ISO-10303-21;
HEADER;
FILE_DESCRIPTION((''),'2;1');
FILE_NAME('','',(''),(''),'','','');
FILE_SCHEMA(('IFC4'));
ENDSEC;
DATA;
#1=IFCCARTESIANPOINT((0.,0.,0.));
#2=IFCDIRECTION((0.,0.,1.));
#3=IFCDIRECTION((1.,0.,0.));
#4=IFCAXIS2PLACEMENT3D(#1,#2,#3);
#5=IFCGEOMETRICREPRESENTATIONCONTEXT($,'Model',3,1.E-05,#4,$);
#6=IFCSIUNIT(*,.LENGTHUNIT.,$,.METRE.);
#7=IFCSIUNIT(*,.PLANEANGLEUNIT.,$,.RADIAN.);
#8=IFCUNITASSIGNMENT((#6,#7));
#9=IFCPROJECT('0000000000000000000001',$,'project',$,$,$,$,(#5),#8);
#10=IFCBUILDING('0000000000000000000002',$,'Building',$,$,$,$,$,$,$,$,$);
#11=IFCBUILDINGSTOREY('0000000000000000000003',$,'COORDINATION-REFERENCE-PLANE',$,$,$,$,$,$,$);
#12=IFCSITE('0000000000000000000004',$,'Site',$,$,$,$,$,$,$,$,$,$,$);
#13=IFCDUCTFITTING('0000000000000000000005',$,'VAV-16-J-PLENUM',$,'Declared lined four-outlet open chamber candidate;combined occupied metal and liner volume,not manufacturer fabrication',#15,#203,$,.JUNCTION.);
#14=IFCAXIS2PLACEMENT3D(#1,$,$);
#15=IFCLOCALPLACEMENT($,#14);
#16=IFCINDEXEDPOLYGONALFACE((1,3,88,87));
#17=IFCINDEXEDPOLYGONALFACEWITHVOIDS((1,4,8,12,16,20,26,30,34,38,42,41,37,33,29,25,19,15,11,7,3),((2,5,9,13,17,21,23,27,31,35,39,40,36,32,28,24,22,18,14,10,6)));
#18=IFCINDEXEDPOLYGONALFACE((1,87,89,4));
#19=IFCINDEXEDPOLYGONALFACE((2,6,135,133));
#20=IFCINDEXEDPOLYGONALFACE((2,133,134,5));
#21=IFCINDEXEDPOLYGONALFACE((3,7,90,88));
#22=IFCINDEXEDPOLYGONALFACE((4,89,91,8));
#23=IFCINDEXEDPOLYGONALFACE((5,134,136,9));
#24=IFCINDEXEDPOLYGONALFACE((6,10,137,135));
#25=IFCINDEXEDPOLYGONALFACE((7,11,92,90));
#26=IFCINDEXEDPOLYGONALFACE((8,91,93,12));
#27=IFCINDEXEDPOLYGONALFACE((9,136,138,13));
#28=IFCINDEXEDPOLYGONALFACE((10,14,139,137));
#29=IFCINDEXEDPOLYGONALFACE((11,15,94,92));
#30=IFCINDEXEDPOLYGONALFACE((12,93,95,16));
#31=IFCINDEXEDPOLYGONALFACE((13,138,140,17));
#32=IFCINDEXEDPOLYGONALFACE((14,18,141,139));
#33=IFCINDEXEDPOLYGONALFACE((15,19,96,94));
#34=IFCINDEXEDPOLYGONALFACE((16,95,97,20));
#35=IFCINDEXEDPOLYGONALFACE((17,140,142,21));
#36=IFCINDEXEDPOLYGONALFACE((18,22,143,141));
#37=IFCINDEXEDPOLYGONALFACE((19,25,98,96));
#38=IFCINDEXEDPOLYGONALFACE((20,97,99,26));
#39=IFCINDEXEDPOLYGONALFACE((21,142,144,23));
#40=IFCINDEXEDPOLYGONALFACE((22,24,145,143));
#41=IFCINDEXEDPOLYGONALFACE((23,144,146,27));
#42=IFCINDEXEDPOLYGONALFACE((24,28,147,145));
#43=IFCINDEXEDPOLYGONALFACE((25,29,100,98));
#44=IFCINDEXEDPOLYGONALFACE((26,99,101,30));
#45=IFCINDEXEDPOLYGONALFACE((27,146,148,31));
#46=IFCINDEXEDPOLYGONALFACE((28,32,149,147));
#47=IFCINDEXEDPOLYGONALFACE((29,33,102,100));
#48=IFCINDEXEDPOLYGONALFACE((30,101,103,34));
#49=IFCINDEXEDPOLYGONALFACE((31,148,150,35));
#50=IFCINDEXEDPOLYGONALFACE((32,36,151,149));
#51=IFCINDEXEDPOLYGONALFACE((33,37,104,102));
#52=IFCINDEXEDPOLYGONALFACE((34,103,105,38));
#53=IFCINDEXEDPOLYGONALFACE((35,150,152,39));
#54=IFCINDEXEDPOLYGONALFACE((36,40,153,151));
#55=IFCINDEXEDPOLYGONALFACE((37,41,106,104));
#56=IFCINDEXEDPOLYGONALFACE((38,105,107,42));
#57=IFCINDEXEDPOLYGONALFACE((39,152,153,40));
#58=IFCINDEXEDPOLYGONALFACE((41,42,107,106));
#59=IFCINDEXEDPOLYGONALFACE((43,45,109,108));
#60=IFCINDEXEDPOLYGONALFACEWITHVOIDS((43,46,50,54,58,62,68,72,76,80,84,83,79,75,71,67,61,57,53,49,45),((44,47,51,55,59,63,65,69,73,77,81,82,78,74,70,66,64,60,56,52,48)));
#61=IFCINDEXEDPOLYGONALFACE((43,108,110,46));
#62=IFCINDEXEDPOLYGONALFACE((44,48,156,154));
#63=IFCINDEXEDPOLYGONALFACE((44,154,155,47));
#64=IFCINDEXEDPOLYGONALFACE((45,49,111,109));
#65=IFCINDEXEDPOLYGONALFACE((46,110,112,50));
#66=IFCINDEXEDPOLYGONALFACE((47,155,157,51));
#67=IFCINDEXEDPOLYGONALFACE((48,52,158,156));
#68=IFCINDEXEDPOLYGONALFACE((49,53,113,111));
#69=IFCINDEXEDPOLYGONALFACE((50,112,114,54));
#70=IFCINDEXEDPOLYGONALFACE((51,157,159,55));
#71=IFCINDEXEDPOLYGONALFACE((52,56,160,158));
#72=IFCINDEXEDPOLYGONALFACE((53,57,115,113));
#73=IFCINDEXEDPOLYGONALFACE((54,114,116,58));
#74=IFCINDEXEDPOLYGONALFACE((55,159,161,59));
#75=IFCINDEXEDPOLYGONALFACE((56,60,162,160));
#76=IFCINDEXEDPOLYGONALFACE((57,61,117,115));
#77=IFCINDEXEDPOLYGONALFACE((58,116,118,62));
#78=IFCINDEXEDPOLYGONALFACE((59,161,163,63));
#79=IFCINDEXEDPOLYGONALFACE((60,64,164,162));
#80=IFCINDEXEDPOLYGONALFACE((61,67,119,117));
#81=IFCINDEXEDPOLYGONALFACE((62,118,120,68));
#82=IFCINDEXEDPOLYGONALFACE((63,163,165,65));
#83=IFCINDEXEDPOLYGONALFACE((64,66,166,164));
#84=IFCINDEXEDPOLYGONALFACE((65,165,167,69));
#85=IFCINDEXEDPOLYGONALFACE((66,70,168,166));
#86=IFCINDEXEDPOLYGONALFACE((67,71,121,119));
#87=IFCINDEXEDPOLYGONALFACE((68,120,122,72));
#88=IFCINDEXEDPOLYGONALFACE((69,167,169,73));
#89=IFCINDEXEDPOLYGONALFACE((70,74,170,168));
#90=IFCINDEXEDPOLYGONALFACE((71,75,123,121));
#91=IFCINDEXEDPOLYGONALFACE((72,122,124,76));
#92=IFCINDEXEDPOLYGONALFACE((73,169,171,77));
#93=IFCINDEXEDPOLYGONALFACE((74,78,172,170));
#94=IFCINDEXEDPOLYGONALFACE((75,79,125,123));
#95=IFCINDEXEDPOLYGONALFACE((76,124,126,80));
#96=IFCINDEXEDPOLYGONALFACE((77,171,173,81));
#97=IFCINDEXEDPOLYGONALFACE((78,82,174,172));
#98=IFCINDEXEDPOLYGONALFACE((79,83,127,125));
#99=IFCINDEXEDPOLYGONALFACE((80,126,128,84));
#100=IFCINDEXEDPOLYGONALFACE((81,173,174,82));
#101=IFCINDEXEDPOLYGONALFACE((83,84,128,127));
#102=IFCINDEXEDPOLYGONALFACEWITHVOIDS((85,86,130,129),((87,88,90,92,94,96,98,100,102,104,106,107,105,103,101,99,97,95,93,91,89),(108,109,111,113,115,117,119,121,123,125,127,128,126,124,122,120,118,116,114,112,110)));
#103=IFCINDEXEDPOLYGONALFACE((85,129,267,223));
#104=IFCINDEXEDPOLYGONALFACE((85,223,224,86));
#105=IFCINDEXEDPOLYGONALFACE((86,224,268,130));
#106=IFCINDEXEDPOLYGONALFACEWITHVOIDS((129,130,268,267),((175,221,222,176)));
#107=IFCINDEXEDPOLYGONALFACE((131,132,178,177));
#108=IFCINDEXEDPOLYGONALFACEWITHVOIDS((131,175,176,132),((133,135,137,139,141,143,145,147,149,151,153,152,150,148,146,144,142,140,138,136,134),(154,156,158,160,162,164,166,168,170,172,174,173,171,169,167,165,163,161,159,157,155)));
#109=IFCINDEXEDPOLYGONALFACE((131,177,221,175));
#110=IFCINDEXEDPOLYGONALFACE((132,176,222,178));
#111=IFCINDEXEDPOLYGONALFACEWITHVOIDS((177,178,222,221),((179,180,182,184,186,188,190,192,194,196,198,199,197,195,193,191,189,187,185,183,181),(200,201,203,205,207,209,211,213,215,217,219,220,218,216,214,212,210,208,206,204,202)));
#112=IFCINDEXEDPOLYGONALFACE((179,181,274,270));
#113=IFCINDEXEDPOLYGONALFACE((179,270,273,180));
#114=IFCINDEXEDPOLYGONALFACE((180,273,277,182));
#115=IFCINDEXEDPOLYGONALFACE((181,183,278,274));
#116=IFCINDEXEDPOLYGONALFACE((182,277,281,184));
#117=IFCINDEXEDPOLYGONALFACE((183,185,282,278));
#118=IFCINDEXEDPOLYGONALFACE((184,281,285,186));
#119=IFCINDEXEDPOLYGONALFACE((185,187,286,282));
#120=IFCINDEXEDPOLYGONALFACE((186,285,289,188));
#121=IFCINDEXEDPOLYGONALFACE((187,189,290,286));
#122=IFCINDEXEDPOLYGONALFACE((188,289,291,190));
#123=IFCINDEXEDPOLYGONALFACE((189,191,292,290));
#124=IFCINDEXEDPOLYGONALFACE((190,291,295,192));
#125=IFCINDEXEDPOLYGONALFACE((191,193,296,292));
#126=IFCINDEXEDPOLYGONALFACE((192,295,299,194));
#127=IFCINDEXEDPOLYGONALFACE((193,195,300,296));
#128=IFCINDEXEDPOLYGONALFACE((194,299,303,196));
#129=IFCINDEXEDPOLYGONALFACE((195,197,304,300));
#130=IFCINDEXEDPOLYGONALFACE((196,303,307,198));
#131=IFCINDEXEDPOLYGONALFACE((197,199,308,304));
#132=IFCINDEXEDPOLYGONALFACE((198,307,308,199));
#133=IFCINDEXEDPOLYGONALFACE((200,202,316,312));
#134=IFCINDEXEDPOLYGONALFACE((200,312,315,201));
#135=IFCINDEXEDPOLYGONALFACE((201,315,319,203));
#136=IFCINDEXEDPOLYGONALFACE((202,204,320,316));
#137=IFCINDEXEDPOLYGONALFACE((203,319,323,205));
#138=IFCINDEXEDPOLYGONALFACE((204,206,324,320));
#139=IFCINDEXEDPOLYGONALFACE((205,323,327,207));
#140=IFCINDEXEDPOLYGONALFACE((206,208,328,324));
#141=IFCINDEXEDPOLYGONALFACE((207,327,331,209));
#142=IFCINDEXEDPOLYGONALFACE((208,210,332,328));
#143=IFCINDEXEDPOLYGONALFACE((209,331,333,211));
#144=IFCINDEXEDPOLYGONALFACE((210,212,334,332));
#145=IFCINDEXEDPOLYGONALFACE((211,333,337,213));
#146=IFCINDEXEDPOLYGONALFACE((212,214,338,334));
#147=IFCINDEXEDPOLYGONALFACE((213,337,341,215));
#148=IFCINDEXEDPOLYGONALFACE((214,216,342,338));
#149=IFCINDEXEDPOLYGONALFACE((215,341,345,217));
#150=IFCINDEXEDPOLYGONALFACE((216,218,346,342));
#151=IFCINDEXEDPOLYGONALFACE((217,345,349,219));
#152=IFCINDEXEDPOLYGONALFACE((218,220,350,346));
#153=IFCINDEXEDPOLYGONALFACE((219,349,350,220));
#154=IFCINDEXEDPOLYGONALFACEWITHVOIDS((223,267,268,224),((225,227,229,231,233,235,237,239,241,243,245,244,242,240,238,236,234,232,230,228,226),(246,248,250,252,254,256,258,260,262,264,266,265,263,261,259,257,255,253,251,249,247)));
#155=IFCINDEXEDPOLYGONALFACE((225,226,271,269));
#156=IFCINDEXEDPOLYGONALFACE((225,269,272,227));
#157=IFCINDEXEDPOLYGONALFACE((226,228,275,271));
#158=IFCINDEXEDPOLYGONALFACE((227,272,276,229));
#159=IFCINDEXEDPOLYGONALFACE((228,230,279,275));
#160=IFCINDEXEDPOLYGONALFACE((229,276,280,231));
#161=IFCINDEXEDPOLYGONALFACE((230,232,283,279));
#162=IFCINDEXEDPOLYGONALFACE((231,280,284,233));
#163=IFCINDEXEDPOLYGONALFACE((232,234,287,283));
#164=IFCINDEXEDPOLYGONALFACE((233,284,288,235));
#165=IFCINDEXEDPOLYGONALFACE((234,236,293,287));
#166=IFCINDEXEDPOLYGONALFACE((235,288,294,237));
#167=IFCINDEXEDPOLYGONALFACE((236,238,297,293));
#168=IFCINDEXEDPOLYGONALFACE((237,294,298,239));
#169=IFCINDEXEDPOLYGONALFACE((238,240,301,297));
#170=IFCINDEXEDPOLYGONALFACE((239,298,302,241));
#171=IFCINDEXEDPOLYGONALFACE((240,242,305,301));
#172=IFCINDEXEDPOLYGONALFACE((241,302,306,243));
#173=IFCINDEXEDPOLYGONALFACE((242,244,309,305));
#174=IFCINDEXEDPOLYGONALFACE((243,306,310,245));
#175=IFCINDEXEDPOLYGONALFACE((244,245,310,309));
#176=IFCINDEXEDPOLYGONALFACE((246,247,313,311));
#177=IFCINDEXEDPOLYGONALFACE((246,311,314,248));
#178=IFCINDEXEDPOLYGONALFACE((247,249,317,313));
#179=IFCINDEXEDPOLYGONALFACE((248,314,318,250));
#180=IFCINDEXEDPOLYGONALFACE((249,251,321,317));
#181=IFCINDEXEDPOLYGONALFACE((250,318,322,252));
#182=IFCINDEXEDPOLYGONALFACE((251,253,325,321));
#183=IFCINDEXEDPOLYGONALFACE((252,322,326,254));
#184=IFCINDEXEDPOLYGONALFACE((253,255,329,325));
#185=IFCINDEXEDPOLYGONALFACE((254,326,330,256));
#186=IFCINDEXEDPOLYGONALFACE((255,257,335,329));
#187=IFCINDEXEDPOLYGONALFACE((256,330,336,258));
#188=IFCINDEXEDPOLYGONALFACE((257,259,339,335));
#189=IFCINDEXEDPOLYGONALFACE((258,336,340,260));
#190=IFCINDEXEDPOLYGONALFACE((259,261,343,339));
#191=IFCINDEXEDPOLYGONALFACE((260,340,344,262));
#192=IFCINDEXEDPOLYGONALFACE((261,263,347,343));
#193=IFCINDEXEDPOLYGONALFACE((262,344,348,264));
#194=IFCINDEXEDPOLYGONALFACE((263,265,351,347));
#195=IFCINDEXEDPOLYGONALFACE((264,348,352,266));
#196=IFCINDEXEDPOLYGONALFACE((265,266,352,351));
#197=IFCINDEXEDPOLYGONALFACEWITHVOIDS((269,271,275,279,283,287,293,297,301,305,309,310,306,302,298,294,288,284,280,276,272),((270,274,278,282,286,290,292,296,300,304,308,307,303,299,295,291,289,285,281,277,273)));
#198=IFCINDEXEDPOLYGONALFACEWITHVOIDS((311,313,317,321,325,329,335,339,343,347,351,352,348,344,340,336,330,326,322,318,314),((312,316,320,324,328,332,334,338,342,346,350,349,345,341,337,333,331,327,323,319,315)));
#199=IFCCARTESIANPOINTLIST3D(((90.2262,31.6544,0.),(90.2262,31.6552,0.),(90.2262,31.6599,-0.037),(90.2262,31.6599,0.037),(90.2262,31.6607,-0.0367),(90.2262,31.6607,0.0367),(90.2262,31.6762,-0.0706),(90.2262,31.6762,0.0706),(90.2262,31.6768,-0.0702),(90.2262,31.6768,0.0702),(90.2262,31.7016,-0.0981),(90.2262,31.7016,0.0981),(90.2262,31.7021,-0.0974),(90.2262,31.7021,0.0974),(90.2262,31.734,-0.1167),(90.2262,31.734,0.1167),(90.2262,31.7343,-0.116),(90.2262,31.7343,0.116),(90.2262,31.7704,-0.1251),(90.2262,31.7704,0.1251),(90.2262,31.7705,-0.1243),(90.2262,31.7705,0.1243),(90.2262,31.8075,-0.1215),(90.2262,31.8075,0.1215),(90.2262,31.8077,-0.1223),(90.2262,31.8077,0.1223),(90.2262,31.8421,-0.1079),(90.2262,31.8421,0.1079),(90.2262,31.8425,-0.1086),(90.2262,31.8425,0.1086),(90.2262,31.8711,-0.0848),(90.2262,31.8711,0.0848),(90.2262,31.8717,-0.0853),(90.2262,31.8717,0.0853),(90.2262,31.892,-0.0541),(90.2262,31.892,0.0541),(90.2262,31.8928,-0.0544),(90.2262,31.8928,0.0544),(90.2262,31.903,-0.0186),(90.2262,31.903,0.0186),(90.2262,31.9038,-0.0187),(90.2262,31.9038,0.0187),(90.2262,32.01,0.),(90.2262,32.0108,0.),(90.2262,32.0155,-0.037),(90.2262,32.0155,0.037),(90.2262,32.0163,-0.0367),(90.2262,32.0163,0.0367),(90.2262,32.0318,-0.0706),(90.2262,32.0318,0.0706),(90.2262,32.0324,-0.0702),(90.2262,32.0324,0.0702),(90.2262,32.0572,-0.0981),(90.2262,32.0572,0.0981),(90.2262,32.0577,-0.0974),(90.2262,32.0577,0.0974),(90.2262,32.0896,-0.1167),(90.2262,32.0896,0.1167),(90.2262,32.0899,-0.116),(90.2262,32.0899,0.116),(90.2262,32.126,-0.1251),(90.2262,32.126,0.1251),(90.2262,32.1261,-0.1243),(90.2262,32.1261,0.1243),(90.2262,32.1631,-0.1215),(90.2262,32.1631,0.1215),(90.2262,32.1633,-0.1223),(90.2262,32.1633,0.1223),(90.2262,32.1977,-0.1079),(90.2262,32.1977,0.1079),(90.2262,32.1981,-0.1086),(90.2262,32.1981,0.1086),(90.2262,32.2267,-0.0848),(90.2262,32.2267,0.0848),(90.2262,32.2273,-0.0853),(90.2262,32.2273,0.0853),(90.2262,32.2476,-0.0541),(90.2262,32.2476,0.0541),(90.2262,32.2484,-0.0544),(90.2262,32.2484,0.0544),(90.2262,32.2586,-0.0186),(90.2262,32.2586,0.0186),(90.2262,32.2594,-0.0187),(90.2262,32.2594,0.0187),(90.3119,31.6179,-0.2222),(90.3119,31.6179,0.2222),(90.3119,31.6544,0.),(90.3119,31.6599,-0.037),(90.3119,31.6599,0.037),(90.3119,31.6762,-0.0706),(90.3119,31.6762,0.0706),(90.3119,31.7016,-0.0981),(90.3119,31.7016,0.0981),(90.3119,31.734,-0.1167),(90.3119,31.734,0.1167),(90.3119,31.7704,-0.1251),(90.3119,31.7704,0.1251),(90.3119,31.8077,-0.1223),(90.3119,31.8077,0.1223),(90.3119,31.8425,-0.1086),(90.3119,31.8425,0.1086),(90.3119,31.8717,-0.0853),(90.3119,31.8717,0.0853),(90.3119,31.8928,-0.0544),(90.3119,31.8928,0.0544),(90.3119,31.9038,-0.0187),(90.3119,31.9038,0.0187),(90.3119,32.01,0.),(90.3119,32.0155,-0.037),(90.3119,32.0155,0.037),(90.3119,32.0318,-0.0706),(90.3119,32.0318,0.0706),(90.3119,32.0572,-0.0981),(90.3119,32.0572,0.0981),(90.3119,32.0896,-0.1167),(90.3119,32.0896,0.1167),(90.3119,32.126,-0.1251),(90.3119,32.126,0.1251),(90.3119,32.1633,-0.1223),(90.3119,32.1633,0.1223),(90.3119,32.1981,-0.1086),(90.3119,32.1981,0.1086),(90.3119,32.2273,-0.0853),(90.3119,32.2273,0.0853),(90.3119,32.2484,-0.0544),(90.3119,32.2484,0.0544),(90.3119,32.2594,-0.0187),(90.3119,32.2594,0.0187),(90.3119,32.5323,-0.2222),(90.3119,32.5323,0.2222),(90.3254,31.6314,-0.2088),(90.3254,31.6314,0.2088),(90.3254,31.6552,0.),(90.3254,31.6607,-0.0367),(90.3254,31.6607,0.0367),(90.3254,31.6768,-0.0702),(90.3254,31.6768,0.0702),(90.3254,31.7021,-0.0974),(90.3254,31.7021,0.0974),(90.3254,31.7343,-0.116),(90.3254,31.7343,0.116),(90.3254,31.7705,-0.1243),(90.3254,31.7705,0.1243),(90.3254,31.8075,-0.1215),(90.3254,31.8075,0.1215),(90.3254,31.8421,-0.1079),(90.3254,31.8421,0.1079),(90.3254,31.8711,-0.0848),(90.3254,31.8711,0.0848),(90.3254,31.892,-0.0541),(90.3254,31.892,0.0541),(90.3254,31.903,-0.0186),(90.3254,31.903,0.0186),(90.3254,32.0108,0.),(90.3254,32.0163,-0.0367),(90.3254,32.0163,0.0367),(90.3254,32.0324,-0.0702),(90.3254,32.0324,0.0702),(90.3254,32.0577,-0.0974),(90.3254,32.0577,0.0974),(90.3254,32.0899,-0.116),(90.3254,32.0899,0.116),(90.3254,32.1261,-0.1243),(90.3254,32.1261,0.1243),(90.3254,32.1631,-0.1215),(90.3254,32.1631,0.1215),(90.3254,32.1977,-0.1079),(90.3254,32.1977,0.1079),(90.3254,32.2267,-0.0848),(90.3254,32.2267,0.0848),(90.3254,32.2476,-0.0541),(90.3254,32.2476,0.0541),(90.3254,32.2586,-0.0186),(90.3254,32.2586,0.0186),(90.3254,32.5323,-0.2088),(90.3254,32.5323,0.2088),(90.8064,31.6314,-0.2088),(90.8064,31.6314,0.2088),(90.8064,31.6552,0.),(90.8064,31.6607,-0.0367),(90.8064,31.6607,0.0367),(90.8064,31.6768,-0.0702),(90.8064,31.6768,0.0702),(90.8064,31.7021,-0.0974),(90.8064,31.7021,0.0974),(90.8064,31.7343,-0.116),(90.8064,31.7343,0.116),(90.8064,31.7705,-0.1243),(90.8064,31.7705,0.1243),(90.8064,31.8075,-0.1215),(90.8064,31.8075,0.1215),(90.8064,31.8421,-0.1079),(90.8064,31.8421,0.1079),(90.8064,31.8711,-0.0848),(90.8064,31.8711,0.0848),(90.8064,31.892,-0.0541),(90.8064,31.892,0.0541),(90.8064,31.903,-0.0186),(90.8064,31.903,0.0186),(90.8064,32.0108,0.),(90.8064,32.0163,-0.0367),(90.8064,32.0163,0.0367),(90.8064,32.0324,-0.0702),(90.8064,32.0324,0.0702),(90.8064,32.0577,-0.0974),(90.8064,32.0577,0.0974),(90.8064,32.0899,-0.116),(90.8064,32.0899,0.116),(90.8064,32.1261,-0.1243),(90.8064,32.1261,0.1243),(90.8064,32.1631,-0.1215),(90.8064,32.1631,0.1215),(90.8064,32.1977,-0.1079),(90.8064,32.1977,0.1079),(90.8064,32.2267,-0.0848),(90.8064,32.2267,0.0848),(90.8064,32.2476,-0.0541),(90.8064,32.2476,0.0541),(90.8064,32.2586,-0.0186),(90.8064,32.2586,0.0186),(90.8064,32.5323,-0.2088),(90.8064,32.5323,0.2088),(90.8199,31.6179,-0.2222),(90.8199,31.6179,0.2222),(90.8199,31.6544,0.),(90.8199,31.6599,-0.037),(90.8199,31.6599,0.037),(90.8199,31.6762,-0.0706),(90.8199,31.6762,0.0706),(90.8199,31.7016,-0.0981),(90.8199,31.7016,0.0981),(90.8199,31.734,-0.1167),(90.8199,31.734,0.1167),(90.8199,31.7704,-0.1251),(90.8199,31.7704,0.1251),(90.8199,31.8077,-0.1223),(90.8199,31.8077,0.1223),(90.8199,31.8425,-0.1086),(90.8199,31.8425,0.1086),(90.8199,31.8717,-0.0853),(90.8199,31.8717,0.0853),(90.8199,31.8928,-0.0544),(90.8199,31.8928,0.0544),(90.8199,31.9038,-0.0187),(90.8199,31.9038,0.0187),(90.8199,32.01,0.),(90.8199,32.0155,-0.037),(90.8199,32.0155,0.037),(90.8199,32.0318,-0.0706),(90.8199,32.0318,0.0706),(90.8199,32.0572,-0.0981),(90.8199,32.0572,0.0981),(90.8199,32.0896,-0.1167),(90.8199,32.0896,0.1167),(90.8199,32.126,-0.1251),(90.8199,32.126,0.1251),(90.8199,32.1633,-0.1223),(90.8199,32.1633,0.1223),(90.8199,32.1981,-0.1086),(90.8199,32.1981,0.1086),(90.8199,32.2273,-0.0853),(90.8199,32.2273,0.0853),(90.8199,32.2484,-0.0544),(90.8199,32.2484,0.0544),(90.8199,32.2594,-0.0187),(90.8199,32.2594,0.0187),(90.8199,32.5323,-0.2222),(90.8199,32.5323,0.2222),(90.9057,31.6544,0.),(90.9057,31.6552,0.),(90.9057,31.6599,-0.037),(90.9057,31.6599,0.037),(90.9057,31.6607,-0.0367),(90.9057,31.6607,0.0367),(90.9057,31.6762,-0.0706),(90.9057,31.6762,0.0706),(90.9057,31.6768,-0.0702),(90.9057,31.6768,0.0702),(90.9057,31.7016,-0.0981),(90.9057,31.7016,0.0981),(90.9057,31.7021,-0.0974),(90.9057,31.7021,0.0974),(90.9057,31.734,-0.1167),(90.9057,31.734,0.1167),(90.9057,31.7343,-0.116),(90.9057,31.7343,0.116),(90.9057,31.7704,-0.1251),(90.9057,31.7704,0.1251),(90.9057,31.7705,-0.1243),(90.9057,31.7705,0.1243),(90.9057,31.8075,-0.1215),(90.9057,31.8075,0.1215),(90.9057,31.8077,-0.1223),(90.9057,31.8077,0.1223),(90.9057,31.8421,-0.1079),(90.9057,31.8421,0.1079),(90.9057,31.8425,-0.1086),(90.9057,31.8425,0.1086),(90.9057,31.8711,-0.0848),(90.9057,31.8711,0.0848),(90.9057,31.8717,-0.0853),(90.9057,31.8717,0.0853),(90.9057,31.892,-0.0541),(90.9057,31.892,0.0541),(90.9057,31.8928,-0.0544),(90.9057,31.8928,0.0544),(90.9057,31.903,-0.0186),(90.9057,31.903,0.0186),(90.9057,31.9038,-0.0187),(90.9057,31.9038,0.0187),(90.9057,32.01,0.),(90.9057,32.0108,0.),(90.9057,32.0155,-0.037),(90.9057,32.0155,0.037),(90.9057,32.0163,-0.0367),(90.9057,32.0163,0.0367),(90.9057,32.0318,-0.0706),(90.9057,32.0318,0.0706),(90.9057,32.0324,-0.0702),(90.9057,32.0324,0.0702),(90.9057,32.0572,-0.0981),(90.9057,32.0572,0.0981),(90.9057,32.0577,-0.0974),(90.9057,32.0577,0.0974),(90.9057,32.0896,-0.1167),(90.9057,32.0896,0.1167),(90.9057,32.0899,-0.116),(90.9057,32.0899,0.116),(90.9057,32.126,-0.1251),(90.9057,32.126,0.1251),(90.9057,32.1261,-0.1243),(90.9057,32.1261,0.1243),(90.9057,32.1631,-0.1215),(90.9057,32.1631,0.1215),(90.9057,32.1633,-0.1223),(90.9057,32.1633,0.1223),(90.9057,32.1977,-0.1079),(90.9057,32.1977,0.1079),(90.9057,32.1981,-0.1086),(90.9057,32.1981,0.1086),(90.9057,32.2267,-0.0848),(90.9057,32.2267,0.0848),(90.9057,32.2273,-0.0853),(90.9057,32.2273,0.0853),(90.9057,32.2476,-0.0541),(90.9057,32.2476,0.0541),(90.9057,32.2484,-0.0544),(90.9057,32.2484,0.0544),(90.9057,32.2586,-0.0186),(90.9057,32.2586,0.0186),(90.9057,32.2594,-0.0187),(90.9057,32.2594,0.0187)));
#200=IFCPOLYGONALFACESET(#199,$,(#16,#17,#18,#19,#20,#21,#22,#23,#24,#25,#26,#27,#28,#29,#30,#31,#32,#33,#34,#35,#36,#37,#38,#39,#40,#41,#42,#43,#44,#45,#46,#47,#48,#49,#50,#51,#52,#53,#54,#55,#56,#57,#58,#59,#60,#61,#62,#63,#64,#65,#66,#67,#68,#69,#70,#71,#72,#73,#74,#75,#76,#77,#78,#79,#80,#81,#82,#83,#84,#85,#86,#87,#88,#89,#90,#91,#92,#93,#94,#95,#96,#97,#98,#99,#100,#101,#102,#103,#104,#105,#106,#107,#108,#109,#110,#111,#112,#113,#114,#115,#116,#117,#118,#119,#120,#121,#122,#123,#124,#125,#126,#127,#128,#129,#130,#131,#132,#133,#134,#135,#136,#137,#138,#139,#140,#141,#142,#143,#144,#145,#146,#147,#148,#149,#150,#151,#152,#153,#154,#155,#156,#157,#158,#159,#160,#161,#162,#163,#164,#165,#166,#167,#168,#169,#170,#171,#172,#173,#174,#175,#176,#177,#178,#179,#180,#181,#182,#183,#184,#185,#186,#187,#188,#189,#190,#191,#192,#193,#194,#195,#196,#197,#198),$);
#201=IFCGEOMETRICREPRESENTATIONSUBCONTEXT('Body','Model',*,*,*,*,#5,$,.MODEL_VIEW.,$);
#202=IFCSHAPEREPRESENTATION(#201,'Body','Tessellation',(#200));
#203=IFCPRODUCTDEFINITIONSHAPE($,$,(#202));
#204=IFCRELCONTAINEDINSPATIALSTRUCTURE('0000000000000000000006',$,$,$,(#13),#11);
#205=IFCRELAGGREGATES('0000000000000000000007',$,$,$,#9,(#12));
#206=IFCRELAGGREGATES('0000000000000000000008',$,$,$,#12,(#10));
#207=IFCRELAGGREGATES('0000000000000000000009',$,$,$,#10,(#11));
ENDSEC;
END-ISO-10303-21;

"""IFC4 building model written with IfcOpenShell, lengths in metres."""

from ifc_helpers import new_model, si_unit, frame, origin_with_axes, place, context, subcontext, project, spatial, rectangle, circle, extrude, boolean, element, save


model = new_model("IFC4")

# Units and contexts
model_context = context("Model", 3, precision=1e-05, world=origin_with_axes())
body_context_1 = subcontext(model_context, "Body", "Model", "MODEL_VIEW")
ifc_project = project(units=[si_unit("LENGTHUNIT", "METRE"), si_unit("PLANEANGLEUNIT", "RADIAN")], contexts=[model_context])

# Site, building, storey
site = spatial("IfcSite", under=ifc_project, Name="Site")
building = spatial("IfcBuilding", under=site, Name="Building")
storey = spatial("IfcBuildingStorey", under=building, Name="COORDINATION-REFERENCE-PLANE")

# Duct fitting
duct_fitting_1_placement = place(None, frame((90.3119, 31.6179, -0.2223), z_axis=(0.0, 0.0, 1.0), x_axis=(1.0, 0.0, 0.0)))
solid_1 = boolean("UNION", boolean("UNION", boolean("UNION", boolean("UNION", extrude(rectangle(XDim=0.481, YDim=0.4175), frame((0.254, 0.9244, 0.2223), z_axis=(0.0, -1.0, 0.0), x_axis=(1.0, 0.0, 0.0)), (0.0, 0.0, 1.0), 0.9109), extrude(circle(Radius=0.1246), frame((0.0235, 0.5175, 0.2223), z_axis=(-1.0, 0.0, 0.0), x_axis=(0.0, -1.0, 0.0)), (0.0, 0.0, 1.0), 0.1192)), extrude(circle(Radius=0.1246), frame((0.4845, 0.5175, 0.2223), z_axis=(1.0, 0.0, 0.0), x_axis=(0.0, -1.0, 0.0)), (0.0, 0.0, 1.0), 0.1192)), extrude(circle(Radius=0.1246), frame((0.0235, 0.1619, 0.2223), z_axis=(-1.0, 0.0, 0.0), x_axis=(0.0, -1.0, 0.0)), (0.0, 0.0, 1.0), 0.1192)), extrude(circle(Radius=0.1246), frame((0.4845, 0.1619, 0.2223), z_axis=(1.0, 0.0, 0.0), x_axis=(0.0, -1.0, 0.0)), (0.0, 0.0, 1.0), 0.1192))
element("IfcDuctFitting", 1, at=duct_fitting_1_placement, inside=storey, Name="VAV-16-J-PLENUM", ObjectType="Declared lined four-outlet open chamber candidate;combined occupied metal and liner volume,not manufacturer fabrication", PredefinedType="JUNCTION", context=body_context_1, shape_type="CSG", body=[
    boolean("DIFFERENCE", boolean("UNION", boolean("UNION", boolean("UNION", boolean("UNION", extrude(rectangle(XDim=0.508, YDim=0.4445), frame((0.254, 0.9144, 0.2223), z_axis=(0.0, -1.0, 0.0), x_axis=(1.0, 0.0, 0.0)), (0.0, 0.0, 1.0), 0.9144), extrude(circle(Radius=0.1254), frame((0.0235, 0.5175, 0.2223), z_axis=(-1.0, 0.0, 0.0), x_axis=(0.0, -1.0, 0.0)), (0.0, 0.0, 1.0), 0.1092)), extrude(circle(Radius=0.1254), frame((0.4845, 0.5175, 0.2223), z_axis=(1.0, 0.0, 0.0), x_axis=(0.0, -1.0, 0.0)), (0.0, 0.0, 1.0), 0.1092)), extrude(circle(Radius=0.1254), frame((0.0235, 0.1619, 0.2223), z_axis=(-1.0, 0.0, 0.0), x_axis=(0.0, -1.0, 0.0)), (0.0, 0.0, 1.0), 0.1092)), extrude(circle(Radius=0.1254), frame((0.4845, 0.1619, 0.2223), z_axis=(1.0, 0.0, 0.0), x_axis=(0.0, -1.0, 0.0)), (0.0, 0.0, 1.0), 0.1092)), solid_1),
])

save(model, "model.ifc")
